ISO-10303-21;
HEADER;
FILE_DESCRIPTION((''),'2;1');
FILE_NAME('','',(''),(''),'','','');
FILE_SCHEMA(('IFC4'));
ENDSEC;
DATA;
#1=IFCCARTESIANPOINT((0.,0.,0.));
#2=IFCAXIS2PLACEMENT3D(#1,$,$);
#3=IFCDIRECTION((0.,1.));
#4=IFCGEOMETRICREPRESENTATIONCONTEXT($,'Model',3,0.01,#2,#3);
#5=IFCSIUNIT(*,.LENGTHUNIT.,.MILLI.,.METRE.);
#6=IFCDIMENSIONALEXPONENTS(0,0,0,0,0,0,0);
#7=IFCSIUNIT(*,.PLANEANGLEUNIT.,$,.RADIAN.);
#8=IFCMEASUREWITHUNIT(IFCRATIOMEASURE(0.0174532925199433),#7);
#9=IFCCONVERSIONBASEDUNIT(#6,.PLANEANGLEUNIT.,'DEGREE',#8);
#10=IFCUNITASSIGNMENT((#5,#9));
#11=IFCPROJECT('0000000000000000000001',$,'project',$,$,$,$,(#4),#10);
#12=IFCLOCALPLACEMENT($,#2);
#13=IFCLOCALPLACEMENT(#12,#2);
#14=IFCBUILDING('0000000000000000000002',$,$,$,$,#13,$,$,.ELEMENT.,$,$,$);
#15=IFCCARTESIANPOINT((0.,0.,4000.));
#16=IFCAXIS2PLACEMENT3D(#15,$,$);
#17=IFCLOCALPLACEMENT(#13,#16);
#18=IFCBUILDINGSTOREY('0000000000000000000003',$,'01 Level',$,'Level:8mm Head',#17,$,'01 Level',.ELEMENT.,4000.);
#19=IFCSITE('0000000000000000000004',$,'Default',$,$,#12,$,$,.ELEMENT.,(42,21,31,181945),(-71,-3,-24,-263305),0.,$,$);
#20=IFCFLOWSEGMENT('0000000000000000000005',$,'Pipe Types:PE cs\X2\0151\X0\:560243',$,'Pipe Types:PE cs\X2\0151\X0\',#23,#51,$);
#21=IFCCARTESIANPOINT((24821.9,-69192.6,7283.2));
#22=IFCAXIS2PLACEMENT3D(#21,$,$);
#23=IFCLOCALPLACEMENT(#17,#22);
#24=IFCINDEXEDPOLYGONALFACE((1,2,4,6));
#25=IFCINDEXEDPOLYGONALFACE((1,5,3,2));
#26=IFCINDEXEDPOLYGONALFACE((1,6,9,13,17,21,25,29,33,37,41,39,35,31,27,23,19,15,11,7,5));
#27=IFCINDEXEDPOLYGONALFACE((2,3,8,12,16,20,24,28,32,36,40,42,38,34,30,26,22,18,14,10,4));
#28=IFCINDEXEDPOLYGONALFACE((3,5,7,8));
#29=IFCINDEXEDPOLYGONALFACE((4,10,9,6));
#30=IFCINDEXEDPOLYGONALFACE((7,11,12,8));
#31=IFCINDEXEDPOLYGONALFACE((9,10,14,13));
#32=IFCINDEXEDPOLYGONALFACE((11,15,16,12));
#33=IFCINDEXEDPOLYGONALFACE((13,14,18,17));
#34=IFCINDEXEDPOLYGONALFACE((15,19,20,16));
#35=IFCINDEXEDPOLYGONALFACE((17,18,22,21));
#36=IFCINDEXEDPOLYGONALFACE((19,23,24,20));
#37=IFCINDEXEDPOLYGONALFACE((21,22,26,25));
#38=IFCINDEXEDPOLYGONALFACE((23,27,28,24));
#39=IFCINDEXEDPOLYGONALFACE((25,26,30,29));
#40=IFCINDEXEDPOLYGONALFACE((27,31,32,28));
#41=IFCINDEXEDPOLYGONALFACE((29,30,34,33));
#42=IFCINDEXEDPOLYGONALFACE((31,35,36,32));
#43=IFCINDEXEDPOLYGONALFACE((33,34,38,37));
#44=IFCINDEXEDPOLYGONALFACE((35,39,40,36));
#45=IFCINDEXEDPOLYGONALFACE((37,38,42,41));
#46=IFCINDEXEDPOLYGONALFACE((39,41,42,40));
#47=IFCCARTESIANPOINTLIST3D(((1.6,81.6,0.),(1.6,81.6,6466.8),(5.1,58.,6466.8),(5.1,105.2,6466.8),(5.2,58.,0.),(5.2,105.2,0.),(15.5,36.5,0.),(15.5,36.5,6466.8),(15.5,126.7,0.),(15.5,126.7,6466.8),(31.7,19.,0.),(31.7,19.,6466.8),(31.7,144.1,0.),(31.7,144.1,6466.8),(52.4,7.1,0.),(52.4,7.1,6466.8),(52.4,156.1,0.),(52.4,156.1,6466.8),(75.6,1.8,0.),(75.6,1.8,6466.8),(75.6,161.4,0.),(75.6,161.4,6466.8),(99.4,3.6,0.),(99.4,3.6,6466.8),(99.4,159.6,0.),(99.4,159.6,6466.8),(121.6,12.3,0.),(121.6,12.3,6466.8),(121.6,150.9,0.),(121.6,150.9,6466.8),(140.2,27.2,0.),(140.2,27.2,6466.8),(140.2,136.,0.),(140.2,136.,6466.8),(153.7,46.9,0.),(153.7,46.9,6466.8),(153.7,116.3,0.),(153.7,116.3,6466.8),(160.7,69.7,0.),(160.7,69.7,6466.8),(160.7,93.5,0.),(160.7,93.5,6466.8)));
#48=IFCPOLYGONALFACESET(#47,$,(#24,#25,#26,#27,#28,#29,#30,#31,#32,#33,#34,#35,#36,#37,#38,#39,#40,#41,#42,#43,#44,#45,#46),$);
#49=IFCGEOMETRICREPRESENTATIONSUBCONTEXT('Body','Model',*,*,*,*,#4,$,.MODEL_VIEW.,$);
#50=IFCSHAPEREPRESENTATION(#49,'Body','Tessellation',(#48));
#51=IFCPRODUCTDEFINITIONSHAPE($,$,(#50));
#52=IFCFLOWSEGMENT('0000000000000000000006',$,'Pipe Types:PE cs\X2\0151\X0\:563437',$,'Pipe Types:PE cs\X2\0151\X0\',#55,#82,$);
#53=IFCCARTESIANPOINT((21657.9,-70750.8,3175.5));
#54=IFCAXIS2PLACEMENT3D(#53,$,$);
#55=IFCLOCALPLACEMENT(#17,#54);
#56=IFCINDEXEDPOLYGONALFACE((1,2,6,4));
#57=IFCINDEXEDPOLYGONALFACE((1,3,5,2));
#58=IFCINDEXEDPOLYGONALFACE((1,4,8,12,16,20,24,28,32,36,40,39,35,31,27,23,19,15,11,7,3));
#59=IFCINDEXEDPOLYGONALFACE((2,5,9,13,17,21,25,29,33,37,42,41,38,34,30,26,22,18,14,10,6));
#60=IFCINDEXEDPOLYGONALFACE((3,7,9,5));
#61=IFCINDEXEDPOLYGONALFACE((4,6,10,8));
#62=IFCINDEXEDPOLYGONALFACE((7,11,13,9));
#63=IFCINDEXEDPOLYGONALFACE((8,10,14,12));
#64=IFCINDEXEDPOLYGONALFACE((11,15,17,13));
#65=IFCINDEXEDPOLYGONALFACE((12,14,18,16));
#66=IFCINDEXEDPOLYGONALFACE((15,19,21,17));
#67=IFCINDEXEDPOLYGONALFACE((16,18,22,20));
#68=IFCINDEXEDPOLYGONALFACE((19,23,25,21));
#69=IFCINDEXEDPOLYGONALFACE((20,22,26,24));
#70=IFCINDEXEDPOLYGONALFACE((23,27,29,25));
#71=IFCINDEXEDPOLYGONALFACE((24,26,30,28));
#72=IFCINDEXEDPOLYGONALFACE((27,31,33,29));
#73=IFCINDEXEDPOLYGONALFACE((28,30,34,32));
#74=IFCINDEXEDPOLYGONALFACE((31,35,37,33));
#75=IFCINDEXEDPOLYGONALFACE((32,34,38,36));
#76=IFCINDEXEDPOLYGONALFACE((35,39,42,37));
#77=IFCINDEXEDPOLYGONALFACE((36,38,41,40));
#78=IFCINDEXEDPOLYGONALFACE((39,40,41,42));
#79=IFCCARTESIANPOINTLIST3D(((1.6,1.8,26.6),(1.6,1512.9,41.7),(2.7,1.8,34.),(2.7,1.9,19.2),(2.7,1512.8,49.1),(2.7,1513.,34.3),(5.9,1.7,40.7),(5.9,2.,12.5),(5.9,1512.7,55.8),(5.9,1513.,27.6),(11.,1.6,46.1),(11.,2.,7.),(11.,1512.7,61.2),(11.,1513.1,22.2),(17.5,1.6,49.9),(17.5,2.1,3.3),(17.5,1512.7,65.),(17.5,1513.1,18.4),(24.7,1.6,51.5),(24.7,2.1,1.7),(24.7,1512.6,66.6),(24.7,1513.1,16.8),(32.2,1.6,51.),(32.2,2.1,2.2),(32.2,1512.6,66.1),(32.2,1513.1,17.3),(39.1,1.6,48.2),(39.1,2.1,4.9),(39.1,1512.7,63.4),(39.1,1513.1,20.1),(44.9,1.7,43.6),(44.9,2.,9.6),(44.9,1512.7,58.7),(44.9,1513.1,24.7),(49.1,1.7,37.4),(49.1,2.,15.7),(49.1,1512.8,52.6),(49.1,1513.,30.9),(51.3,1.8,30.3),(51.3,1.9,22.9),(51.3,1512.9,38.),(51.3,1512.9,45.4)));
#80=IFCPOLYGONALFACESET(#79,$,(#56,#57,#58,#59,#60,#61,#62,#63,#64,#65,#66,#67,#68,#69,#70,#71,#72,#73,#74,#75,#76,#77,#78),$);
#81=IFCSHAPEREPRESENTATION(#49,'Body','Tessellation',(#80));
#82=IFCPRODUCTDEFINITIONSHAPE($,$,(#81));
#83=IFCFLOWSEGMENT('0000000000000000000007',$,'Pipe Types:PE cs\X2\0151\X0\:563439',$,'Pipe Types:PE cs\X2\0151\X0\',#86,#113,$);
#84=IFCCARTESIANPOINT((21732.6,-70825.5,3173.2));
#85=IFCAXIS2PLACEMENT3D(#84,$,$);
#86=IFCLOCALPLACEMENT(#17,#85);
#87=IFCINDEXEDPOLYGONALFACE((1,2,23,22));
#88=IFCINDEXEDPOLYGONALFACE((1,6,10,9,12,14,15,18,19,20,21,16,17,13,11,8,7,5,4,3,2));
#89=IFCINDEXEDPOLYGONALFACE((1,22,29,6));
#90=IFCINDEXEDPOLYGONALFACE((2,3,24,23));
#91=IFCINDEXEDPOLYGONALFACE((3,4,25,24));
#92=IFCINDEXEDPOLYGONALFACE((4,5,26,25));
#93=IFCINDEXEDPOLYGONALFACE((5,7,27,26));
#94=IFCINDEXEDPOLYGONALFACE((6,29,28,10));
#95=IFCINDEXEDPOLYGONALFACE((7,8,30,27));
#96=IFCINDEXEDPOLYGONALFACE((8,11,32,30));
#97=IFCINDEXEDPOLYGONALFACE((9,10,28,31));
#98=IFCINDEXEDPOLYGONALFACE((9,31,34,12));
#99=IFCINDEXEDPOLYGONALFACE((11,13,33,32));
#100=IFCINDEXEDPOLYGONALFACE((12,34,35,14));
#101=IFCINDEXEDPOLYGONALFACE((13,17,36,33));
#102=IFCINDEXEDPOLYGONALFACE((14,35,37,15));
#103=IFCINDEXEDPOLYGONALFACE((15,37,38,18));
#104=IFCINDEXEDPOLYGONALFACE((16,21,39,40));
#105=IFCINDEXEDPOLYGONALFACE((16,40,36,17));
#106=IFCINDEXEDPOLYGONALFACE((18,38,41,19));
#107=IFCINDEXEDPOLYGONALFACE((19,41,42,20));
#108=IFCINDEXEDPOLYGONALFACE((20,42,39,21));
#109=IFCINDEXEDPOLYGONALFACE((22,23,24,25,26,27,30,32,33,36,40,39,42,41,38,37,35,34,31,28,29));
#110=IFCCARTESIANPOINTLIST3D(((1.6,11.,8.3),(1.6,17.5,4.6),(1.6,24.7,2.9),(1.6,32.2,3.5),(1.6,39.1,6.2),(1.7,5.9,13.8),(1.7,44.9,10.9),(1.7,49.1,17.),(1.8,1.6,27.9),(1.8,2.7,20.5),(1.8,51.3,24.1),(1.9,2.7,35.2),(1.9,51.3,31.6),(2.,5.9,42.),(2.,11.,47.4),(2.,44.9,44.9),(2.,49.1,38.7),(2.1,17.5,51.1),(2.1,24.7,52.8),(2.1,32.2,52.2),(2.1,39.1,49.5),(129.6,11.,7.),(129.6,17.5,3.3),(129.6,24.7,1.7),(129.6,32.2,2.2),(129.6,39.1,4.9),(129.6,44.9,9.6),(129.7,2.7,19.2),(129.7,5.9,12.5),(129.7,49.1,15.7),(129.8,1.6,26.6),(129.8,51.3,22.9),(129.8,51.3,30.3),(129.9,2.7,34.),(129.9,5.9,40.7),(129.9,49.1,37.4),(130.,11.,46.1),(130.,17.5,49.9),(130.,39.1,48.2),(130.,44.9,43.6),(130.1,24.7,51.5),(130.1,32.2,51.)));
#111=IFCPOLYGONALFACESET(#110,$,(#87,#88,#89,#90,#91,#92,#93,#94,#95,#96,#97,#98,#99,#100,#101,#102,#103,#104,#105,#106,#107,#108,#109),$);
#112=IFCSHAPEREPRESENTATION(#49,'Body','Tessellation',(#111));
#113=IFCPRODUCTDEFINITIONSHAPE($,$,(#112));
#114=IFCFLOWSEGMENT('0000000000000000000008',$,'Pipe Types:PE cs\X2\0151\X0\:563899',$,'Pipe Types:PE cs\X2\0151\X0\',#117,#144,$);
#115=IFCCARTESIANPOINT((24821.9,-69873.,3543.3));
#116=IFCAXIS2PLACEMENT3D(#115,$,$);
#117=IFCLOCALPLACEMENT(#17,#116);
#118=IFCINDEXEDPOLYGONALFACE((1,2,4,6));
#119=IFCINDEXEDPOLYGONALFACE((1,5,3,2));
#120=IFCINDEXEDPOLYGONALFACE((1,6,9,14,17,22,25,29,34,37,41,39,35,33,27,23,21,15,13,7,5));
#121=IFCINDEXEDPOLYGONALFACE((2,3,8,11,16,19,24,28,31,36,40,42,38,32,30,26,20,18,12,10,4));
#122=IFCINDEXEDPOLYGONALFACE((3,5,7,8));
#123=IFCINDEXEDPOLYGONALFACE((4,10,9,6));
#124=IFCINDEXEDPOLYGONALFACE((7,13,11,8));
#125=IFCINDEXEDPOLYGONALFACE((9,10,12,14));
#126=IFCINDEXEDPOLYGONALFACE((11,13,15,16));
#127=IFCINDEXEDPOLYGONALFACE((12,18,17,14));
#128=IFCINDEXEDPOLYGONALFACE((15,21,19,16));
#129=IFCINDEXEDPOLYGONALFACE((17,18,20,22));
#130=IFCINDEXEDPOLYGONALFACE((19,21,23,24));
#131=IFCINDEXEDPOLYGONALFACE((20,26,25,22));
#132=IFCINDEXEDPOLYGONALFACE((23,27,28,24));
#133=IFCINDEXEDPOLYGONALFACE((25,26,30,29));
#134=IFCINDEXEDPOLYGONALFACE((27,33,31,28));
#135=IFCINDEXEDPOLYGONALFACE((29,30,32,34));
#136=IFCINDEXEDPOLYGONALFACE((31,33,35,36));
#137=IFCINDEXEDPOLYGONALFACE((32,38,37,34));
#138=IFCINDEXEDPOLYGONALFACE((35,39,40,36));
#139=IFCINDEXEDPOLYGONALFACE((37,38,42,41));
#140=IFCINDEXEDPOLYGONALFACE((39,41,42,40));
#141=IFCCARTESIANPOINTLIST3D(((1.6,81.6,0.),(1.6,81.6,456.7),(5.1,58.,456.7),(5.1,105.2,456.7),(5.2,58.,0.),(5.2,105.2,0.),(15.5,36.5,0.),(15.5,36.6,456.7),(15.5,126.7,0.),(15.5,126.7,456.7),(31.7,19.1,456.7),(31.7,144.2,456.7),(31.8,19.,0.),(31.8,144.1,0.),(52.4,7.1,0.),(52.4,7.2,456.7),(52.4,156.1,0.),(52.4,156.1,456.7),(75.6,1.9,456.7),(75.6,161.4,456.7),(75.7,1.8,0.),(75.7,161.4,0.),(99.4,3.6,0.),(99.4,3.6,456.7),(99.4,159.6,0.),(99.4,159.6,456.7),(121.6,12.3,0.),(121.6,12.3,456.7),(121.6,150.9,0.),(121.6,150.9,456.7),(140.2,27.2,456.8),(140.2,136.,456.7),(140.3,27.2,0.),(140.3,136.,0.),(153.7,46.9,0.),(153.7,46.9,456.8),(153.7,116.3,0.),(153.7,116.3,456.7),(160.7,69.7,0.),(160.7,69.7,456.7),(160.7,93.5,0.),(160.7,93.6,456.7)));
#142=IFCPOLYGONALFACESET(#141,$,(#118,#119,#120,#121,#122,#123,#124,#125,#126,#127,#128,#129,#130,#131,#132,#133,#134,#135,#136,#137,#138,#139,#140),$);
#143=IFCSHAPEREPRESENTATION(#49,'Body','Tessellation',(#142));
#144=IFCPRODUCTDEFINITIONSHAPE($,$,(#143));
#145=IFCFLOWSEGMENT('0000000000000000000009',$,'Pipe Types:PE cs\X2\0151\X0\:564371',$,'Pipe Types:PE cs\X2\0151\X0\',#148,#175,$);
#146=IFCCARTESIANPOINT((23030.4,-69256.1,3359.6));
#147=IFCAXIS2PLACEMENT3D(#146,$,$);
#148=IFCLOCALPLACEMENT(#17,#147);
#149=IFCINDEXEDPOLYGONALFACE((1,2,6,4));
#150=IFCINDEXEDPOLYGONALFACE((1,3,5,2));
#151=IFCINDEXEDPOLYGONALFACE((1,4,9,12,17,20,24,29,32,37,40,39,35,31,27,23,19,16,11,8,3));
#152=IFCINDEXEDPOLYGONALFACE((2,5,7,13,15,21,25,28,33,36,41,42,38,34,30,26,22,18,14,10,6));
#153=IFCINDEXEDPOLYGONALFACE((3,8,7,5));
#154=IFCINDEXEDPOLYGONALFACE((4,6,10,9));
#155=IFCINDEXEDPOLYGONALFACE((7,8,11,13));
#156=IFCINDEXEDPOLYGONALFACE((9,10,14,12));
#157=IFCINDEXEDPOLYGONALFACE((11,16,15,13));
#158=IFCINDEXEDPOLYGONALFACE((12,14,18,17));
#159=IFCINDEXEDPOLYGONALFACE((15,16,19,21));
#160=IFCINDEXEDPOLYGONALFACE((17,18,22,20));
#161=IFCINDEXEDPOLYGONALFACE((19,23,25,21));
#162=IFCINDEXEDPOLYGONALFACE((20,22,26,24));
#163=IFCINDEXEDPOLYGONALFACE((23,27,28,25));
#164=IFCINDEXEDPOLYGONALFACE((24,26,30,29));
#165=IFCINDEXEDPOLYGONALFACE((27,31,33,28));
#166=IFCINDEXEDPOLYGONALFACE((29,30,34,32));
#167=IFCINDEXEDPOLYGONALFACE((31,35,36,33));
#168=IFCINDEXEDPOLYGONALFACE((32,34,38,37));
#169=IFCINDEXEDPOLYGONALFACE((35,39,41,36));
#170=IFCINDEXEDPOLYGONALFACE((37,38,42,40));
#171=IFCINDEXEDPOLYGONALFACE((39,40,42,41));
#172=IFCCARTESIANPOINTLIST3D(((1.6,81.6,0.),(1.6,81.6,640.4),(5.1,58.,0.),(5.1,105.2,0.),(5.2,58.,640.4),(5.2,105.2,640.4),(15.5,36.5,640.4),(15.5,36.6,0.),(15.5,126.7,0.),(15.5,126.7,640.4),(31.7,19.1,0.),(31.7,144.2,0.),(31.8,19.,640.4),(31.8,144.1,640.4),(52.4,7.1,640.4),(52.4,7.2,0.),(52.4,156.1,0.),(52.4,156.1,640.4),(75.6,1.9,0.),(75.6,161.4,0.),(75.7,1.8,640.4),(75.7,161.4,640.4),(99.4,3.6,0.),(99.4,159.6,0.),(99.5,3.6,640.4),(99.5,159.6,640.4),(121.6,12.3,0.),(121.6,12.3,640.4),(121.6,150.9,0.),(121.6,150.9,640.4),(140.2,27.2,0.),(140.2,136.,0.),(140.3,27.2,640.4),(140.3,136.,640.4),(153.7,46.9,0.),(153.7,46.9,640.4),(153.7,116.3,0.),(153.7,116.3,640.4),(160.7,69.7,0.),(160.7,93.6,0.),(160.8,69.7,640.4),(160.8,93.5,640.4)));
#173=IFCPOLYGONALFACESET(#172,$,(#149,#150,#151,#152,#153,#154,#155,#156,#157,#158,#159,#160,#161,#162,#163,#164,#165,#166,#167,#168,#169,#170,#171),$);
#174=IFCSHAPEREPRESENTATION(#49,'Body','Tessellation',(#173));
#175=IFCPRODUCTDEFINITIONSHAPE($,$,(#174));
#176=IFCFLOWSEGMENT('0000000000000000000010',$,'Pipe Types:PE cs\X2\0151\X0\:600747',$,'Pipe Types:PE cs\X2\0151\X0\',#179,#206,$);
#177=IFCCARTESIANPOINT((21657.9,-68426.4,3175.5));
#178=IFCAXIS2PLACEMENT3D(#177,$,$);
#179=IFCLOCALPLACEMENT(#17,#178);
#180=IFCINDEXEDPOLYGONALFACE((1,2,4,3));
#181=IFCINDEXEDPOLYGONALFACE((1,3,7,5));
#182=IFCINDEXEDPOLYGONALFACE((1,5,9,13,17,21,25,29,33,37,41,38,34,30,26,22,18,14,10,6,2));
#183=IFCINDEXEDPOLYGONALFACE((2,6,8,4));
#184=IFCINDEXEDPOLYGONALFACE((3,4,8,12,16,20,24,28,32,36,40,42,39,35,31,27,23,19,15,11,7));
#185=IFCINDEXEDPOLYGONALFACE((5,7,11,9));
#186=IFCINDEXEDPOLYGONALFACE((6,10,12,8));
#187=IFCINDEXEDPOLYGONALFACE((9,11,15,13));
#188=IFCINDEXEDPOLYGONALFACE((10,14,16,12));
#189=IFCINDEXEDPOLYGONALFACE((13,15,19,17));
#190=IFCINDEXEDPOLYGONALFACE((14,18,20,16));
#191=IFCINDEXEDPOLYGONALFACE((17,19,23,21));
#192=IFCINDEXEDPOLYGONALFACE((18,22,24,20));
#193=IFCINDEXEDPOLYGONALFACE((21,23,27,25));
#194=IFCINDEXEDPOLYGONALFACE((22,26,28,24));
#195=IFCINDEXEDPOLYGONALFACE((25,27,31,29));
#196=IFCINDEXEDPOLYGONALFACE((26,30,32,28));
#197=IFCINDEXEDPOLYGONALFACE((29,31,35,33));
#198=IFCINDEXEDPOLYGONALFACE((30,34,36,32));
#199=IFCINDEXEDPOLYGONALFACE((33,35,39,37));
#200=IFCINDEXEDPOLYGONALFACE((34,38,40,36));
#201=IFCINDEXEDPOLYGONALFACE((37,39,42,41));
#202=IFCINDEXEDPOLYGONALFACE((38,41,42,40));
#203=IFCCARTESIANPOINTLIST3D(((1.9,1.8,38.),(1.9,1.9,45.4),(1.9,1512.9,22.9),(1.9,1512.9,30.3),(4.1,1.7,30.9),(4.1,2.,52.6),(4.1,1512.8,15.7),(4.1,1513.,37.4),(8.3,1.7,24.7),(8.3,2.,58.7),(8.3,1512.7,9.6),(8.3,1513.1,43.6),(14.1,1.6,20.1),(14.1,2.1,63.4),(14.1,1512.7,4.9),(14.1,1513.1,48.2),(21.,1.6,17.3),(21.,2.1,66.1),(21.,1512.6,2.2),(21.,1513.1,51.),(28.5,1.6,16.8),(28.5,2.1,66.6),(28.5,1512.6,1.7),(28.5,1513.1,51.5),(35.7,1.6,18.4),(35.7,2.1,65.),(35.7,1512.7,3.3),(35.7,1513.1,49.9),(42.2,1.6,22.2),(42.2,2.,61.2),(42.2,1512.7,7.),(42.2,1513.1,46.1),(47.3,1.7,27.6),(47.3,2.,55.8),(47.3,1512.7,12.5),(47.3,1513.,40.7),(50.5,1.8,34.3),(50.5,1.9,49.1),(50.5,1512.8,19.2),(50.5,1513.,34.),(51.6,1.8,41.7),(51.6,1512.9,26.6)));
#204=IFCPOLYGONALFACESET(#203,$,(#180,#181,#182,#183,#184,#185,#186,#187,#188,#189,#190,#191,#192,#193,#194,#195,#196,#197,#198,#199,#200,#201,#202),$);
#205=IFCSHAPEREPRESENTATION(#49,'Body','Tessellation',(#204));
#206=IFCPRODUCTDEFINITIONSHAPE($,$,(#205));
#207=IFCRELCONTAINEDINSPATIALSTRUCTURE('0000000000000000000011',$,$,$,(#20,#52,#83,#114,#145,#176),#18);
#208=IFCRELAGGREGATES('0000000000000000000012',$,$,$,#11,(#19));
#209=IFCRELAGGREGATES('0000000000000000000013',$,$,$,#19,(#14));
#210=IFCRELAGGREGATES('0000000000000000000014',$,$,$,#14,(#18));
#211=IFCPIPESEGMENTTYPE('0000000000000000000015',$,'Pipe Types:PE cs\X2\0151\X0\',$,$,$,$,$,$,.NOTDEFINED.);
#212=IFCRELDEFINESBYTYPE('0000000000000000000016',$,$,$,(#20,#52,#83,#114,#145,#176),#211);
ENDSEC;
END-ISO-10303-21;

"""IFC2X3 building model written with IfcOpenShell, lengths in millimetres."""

from ifc_helpers import new_model, entity, si_unit, converted_unit, direction, frame, frame_2d, origin, origin_2d_with_axis, place, context, subcontext, project, spatial, circle, extrude, type_object, element, save


model = new_model("IFC2X3")

# Units and contexts
model_context = context("Model", 3, precision=0.01, world=origin(), true_north=direction((0.0, 1.0)))
body_context = subcontext(model_context, "Body", "Model", "MODEL_VIEW")
ifc_project = project(units=[si_unit("LENGTHUNIT", "METRE", prefix="MILLI"), converted_unit("PLANEANGLEUNIT", "DEGREE", entity("IfcRatioMeasure", 0.0174532925199433), si_unit("PLANEANGLEUNIT", "RADIAN"), dimensions=[0, 0, 0, 0, 0, 0, 0])], contexts=[model_context])

# Site, building, storey
site_placement = place(None, origin())
site = spatial("IfcSite", under=ifc_project, at=site_placement, Name="Default", CompositionType="ELEMENT", RefLatitude=(42, 21, 31, 181945), RefLongitude=(-71, -3, -24, -263305), RefElevation=0.0)
building_placement = place(site_placement, origin())
building = spatial("IfcBuilding", under=site, at=building_placement, CompositionType="ELEMENT")
storey_placement = place(building_placement, frame((0.0, 0.0, 4000.0)))
storey = spatial("IfcBuildingStorey", under=building, at=storey_placement, Name="01 Level", ObjectType="Level:8mm Head", LongName="01 Level", CompositionType="ELEMENT", Elevation=4000.0)

# Flow segments
pipe_segment_type = type_object("IfcPipeSegmentType", Name="Pipe Types:PE cső", PredefinedType="NOTDEFINED")
flow_segment_1_placement = place(storey_placement, frame((24821.9, -69192.6, 7283.2)))
element("IfcFlowSegment", 1, at=flow_segment_1_placement, inside=storey, type_object=pipe_segment_type, Name="Pipe Types:PE cső:560243", ObjectType="Pipe Types:PE cső", context=body_context, shape_type="SweptSolid", body=[
    extrude(circle(Radius=80.0, at=origin_2d_with_axis()), frame((81.6, 81.6, 0.0), z_axis=(-0.000001, 0.0, 1.0), x_axis=(-1.0, 0.0, -0.000001)), (0.0, 0.0, 1.0), 6466.8),
])
flow_segment_2_placement = place(storey_placement, frame((21657.9, -70750.8, 3175.5)))
element("IfcFlowSegment", 2, at=flow_segment_2_placement, inside=storey, type_object=pipe_segment_type, Name="Pipe Types:PE cső:563437", ObjectType="Pipe Types:PE cső", context=body_context, shape_type="SweptSolid", body=[
    extrude(circle(Radius=25.0, at=frame_2d((0.0, 0.0), x_axis=(1.0, 0.0))), frame((26.6, 1.8, 26.6), z_axis=(0.0, 0.99995, 0.01), x_axis=(-1.0, 0.0, 0.0)), (0.0, 0.0, 1.0), 1511.1),
])
flow_segment_3_placement = place(storey_placement, frame((21732.6, -70825.5, 3173.2)))
element("IfcFlowSegment", 3, at=flow_segment_3_placement, inside=storey, type_object=pipe_segment_type, Name="Pipe Types:PE cső:563439", ObjectType="Pipe Types:PE cső", context=body_context, shape_type="SweptSolid", body=[
    extrude(circle(Radius=25.0, at=origin_2d_with_axis()), frame((129.8, 26.6, 26.6), z_axis=(-0.99995, 0.0, 0.01), x_axis=(0.0, -1.0, 0.0)), (0.0, 0.0, 1.0), 128.0),
])
flow_segment_4_placement = place(storey_placement, frame((24821.9, -69873.0, 3543.3)))
element("IfcFlowSegment", 4, at=flow_segment_4_placement, inside=storey, type_object=pipe_segment_type, Name="Pipe Types:PE cső:563899", ObjectType="Pipe Types:PE cső", context=body_context, shape_type="SweptSolid", body=[
    extrude(circle(Radius=80.0, at=origin_2d_with_axis()), frame((81.6, 81.6, 0.0), z_axis=(-0.000102, 0.00007, 1.0), x_axis=(-1.0, 0.0, -0.000102)), (0.0, 0.0, 1.0), 456.7),
])
flow_segment_5_placement = place(storey_placement, frame((23030.4, -69256.1, 3359.6)))
element("IfcFlowSegment", 5, at=flow_segment_5_placement, inside=storey, type_object=pipe_segment_type, Name="Pipe Types:PE cső:564371", ObjectType="Pipe Types:PE cső", context=body_context, shape_type="SweptSolid", body=[
    extrude(circle(Radius=80.0, at=frame_2d((0.0, 0.0), x_axis=(1.0, 0.0))), frame((81.6, 81.6, 0.0), z_axis=(0.000084, -0.000051, 1.0), x_axis=(-1.0, 0.0, 0.000084)), (0.0, 0.0, 1.0), 640.4),
])
flow_segment_6_placement = place(storey_placement, frame((21657.9, -68426.4, 3175.5)))
element("IfcFlowSegment", 6, at=flow_segment_6_placement, inside=storey, type_object=pipe_segment_type, Name="Pipe Types:PE cső:600747", ObjectType="Pipe Types:PE cső", context=body_context, shape_type="SweptSolid", body=[
    extrude(circle(Radius=25.0, at=frame_2d((0.0, 0.0), x_axis=(1.0, 0.0))), frame((26.6, 1512.9, 26.6), z_axis=(0.0, -0.99995, 0.01), x_axis=(1.0, 0.0, 0.0)), (0.0, 0.0, 1.0), 1511.1),
])

save(model, "model.ifc")
